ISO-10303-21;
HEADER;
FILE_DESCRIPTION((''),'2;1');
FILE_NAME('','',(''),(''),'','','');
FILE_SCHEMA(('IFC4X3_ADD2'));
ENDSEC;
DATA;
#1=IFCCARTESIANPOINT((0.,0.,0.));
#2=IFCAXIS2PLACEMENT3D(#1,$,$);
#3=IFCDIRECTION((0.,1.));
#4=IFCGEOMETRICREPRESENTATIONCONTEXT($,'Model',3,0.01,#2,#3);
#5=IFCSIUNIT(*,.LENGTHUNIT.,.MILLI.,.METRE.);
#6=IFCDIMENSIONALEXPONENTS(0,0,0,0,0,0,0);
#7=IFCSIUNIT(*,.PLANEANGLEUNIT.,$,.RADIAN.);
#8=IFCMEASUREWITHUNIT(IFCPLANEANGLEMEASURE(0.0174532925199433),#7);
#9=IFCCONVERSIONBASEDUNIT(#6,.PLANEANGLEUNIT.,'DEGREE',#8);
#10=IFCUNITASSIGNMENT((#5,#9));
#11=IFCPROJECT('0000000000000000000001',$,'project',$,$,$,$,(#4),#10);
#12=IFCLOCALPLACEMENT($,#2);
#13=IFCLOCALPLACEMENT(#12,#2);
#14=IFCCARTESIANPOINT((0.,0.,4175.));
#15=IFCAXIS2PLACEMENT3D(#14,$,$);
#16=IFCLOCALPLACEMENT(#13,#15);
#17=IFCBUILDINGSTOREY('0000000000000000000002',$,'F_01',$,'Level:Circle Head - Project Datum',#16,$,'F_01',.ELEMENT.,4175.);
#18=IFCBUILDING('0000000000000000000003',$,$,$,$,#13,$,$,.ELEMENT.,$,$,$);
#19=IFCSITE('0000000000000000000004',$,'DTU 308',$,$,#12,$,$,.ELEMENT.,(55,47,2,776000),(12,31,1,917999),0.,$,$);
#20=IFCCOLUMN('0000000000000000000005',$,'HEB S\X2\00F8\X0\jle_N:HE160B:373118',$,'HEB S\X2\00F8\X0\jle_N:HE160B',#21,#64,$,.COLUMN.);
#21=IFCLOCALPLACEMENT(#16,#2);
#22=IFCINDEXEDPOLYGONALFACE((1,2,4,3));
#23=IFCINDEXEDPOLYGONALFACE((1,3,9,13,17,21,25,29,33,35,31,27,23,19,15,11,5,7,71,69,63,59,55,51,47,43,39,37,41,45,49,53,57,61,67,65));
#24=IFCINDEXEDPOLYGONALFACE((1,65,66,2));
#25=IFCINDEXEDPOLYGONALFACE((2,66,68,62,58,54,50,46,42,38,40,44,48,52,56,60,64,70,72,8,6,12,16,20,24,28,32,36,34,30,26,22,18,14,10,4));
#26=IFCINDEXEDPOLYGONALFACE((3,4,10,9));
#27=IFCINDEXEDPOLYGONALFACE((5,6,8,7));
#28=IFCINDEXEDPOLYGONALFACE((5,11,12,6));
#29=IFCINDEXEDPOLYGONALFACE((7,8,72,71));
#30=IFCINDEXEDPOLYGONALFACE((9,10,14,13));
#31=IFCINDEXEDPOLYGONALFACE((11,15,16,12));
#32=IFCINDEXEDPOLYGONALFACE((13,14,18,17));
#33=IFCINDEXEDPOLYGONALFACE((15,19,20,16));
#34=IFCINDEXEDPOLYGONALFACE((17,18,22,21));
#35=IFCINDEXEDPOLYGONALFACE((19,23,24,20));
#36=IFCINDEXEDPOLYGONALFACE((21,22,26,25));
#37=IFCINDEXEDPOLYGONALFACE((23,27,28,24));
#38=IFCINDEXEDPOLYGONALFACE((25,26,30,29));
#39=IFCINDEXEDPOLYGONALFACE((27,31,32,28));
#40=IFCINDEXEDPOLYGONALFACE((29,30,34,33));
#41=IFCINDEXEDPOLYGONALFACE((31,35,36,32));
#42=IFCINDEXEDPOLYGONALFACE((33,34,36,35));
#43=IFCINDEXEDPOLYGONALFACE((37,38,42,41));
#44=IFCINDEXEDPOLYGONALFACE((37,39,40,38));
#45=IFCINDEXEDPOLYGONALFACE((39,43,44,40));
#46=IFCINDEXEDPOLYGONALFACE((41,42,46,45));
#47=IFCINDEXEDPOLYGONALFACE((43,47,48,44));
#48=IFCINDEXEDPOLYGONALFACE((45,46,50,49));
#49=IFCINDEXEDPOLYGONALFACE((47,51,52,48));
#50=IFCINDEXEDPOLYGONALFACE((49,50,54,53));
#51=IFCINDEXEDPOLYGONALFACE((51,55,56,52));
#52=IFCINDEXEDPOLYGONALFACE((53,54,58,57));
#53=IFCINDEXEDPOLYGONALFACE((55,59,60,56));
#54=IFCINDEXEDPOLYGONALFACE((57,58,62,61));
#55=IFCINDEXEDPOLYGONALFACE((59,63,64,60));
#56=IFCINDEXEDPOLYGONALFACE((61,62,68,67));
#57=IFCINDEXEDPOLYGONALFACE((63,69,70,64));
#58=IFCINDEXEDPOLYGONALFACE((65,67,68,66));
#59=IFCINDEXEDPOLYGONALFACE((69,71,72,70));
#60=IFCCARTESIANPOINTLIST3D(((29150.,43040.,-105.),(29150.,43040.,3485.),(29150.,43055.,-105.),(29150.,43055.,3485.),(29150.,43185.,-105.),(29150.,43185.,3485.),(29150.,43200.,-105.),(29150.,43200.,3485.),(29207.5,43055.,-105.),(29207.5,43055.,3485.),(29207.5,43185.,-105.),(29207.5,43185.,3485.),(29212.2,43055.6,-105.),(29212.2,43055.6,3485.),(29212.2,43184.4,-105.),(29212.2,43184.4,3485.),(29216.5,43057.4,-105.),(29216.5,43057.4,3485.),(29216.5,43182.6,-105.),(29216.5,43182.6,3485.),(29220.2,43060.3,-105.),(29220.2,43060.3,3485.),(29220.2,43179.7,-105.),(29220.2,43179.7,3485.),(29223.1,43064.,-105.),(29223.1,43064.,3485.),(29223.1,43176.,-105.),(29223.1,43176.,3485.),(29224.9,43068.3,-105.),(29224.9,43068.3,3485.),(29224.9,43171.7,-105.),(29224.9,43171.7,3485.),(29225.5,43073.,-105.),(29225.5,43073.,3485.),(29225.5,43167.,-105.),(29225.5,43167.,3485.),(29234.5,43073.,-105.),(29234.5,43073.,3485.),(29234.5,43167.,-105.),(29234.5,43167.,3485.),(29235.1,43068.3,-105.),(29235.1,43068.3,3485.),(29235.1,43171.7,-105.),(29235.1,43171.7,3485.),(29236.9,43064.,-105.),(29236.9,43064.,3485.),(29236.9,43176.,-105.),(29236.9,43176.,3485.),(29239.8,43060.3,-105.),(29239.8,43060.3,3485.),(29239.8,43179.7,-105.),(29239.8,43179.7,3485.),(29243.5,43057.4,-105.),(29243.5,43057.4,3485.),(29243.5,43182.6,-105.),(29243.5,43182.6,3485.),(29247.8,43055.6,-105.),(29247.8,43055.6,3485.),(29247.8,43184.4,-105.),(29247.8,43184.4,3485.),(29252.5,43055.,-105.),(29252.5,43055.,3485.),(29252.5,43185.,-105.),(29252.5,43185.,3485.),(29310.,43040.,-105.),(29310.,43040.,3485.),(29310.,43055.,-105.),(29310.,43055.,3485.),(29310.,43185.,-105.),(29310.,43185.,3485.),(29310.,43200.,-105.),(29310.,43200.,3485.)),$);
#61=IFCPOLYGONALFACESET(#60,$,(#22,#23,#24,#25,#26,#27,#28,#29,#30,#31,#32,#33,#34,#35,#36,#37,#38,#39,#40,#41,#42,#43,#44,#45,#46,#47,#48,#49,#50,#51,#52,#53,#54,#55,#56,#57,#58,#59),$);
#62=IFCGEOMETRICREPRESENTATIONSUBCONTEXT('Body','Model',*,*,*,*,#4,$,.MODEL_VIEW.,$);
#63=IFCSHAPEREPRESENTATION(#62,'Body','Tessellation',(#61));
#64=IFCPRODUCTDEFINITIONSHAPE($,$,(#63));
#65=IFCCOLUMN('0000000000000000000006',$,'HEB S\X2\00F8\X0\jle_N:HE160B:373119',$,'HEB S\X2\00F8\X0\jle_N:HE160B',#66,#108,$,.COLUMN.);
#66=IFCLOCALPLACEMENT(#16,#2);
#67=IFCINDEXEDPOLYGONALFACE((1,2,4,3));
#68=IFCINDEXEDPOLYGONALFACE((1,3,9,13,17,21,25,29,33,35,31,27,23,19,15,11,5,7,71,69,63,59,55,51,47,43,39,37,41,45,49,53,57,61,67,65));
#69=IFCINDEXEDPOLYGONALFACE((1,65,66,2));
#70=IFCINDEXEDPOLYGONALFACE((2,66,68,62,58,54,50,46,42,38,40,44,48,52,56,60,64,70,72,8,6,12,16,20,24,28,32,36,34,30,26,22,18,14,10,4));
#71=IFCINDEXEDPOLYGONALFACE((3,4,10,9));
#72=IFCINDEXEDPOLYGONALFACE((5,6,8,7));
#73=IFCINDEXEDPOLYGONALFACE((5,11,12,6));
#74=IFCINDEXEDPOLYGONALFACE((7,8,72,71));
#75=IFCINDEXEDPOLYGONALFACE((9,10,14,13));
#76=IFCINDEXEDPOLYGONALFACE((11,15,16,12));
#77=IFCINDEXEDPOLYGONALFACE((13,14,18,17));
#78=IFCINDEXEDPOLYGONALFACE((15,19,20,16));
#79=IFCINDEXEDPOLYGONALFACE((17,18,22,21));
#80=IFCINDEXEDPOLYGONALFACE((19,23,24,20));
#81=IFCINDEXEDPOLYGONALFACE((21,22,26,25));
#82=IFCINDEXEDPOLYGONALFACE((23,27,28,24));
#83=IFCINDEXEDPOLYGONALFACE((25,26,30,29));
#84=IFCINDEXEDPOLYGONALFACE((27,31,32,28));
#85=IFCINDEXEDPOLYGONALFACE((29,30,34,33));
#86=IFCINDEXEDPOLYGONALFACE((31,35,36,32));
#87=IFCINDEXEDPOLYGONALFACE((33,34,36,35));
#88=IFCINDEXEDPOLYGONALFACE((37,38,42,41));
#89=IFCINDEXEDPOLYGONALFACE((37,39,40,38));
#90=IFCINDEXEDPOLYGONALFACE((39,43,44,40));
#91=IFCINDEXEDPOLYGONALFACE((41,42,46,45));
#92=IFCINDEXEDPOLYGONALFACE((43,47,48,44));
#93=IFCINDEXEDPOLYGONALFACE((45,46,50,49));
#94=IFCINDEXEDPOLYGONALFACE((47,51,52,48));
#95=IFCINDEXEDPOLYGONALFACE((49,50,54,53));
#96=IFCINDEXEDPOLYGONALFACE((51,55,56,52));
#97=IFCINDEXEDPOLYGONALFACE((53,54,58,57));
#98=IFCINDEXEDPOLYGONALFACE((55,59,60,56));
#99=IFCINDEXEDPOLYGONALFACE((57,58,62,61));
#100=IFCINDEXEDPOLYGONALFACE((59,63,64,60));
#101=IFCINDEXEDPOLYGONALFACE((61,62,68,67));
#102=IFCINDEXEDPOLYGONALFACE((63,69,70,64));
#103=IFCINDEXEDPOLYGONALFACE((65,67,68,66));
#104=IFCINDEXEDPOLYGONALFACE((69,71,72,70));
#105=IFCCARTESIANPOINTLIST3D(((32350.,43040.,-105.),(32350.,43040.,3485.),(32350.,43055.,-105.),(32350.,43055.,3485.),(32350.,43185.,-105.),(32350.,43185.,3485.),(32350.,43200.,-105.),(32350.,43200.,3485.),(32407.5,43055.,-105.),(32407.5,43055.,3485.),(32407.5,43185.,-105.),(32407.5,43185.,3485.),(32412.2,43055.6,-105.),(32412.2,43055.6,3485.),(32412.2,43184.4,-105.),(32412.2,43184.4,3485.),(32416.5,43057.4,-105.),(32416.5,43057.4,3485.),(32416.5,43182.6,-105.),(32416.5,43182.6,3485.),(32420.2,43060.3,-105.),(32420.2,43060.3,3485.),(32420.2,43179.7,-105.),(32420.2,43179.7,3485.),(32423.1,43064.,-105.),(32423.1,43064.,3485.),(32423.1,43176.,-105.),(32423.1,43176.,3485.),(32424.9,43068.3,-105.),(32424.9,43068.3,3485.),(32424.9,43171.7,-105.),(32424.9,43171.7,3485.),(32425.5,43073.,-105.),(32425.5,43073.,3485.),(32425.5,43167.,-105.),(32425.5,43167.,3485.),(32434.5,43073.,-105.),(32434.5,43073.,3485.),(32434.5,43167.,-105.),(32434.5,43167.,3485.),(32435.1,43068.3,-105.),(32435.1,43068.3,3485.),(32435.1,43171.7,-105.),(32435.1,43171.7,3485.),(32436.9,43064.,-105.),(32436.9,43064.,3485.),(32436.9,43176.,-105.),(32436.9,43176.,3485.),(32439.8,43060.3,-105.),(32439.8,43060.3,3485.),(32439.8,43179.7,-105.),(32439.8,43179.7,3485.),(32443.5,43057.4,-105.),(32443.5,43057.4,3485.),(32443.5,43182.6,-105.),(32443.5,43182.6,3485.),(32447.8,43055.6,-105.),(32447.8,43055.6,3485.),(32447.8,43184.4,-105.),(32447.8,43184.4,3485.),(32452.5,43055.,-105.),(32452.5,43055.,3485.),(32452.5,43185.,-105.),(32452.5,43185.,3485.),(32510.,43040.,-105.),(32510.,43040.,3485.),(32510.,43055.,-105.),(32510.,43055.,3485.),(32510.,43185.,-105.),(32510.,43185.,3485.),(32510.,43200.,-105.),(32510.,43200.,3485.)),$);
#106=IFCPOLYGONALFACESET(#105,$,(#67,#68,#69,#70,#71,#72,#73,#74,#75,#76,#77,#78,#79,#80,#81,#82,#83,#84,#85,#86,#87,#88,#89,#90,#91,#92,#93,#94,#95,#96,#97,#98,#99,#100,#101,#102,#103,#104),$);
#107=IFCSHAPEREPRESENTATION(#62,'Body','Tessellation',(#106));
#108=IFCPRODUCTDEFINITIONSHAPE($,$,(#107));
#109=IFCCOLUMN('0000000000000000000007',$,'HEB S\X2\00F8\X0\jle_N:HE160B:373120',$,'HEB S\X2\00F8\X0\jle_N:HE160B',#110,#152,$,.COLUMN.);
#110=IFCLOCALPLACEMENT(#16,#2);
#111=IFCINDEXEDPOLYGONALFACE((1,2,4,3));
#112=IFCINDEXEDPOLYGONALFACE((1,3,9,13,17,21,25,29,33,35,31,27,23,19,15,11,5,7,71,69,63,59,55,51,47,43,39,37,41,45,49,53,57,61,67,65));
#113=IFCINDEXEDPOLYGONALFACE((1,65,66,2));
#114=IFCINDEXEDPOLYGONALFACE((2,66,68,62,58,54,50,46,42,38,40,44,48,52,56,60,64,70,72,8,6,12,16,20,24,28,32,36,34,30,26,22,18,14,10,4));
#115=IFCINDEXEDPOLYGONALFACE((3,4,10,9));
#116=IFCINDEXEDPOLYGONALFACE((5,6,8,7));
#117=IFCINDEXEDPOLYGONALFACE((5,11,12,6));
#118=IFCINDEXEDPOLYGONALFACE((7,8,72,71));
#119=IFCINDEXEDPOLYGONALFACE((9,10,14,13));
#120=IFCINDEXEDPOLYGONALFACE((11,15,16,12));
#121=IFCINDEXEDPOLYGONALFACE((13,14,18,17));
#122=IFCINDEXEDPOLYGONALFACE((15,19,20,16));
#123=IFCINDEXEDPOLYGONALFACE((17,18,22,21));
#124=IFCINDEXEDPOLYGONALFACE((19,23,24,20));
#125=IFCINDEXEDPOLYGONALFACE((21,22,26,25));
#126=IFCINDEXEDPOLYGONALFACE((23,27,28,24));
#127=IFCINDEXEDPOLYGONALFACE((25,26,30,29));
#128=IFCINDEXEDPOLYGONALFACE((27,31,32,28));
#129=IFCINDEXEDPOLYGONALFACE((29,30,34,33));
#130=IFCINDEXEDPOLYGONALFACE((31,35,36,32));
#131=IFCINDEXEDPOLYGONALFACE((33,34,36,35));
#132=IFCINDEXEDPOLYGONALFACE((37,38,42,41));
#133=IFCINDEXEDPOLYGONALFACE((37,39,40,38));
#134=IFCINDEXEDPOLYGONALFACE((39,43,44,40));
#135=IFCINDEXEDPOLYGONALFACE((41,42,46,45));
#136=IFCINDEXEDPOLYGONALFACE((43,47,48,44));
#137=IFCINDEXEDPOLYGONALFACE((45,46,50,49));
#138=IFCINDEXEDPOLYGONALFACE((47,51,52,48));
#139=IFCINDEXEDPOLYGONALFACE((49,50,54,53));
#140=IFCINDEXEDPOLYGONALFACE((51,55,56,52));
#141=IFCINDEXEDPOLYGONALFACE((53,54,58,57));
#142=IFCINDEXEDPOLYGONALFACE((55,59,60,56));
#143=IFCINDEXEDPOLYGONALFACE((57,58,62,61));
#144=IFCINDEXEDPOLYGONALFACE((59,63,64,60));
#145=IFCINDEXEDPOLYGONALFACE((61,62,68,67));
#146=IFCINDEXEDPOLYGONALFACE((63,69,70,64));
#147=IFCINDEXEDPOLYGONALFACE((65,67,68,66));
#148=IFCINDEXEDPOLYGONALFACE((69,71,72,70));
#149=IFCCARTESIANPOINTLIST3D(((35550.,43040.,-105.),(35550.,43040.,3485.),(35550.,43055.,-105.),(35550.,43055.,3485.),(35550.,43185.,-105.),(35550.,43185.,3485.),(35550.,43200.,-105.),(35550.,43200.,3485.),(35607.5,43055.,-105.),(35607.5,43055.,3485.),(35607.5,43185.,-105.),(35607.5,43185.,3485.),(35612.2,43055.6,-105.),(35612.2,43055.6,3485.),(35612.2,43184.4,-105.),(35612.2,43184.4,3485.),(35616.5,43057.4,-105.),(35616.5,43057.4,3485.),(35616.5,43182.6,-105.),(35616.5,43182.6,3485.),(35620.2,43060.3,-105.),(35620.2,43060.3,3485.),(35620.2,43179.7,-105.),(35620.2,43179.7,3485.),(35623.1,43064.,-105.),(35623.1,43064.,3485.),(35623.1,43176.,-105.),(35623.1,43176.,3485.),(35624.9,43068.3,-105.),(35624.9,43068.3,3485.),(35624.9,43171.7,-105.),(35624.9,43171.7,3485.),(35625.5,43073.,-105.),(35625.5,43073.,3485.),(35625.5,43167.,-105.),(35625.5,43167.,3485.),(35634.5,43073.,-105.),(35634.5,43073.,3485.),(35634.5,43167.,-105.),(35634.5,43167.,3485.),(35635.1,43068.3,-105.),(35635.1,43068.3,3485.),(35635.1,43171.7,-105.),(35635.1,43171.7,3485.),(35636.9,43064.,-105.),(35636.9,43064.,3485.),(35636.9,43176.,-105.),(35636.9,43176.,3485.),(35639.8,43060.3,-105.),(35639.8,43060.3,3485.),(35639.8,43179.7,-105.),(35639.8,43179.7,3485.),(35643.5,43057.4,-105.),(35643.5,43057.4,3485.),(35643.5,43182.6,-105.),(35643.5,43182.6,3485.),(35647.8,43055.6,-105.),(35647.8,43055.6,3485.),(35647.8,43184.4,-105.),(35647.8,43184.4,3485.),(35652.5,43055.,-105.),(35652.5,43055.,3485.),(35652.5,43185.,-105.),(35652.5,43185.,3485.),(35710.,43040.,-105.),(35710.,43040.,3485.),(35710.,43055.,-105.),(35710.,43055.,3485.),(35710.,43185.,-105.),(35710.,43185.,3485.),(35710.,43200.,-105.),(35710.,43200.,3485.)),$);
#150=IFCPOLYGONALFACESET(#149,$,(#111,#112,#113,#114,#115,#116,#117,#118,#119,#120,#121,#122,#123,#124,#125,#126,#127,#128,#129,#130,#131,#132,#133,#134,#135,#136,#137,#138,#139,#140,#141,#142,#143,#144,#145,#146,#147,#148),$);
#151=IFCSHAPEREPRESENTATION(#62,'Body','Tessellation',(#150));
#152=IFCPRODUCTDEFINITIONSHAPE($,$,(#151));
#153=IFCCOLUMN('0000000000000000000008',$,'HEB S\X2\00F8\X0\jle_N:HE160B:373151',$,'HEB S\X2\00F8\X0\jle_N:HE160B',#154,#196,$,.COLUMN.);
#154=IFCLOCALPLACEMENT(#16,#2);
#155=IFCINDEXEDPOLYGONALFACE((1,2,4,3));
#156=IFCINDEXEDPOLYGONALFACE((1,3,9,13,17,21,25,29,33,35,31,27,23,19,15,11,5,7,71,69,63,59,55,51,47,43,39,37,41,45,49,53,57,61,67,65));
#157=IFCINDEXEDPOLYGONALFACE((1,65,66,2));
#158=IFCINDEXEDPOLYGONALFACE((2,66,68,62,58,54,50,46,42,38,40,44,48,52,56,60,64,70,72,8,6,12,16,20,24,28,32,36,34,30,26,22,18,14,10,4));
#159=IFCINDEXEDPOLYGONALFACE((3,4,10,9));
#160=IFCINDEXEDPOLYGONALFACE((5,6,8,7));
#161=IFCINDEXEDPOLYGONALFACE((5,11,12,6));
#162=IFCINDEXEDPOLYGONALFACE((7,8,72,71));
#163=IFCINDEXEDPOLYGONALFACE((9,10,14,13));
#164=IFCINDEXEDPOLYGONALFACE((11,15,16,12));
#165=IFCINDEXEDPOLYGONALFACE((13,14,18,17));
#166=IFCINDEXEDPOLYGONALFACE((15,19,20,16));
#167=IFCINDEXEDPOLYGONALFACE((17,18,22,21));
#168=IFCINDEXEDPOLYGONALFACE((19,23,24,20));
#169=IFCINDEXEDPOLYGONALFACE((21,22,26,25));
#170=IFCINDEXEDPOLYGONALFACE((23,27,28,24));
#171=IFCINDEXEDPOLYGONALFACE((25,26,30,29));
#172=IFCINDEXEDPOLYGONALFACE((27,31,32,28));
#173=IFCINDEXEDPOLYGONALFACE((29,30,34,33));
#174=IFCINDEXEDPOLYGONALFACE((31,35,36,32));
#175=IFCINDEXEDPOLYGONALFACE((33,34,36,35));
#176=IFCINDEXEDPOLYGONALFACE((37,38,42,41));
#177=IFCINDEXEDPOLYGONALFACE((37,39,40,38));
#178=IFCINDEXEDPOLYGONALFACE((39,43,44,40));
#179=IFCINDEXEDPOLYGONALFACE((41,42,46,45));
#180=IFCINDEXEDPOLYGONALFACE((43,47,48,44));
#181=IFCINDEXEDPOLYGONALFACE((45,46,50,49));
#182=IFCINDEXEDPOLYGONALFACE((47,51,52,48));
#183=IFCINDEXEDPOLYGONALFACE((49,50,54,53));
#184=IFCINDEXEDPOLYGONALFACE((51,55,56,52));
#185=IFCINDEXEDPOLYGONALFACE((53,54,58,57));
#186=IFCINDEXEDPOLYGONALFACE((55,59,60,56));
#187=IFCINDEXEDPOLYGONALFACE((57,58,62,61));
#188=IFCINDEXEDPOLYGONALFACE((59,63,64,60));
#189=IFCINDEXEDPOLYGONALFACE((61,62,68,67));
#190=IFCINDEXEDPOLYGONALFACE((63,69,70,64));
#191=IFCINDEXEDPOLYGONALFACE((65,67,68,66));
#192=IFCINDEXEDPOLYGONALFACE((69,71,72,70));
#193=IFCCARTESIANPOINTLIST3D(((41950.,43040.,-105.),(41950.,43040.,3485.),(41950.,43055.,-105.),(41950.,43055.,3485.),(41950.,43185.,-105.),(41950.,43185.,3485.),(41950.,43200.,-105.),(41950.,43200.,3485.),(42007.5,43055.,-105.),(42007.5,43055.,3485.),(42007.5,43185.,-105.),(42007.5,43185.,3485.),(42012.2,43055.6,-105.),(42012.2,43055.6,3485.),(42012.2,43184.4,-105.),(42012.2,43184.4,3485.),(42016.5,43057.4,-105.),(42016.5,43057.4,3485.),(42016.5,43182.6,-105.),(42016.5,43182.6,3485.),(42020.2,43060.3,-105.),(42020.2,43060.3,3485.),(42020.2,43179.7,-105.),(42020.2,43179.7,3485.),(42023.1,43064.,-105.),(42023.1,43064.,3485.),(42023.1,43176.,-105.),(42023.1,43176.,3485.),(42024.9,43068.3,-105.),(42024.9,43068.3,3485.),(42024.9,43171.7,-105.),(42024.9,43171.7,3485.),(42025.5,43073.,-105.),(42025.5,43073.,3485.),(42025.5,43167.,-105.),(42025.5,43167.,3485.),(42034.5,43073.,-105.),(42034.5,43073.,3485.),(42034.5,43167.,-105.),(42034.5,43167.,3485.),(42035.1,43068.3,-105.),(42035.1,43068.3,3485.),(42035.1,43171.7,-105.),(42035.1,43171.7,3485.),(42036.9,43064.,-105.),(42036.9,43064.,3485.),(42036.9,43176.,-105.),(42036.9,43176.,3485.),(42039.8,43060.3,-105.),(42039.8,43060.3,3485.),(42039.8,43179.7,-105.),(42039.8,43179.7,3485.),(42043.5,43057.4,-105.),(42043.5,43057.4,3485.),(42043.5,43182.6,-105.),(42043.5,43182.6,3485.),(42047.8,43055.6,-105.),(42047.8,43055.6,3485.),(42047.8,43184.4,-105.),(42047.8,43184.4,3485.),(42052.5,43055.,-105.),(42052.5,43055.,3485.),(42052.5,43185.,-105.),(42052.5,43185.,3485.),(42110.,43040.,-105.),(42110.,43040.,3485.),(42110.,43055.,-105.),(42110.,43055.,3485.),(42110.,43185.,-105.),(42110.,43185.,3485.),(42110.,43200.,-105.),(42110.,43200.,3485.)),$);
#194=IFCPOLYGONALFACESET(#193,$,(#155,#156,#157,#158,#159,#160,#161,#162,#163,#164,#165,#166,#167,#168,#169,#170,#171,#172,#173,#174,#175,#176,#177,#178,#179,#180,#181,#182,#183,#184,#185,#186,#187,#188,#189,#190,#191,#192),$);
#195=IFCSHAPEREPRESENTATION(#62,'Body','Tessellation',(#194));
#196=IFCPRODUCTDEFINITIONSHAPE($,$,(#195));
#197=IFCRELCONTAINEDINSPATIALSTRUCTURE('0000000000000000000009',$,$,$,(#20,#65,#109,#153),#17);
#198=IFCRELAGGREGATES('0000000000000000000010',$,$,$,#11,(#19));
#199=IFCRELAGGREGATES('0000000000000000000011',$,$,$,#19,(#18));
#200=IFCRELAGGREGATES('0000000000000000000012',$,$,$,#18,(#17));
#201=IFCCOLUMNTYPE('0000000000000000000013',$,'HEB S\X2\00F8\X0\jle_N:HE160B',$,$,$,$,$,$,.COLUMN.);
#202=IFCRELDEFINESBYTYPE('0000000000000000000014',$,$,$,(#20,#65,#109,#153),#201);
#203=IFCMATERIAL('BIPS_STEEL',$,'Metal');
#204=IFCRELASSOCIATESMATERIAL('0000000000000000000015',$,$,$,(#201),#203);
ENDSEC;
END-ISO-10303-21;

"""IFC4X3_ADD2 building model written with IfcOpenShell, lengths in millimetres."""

from ifc_helpers import new_model, entity, si_unit, converted_unit, direction, frame, frame_2d, origin, place, context, subcontext, project, spatial, i_section, extrude, source, transform, mapped, material, material_profile, profile_set, type_object, element, save


model = new_model("IFC4X3_ADD2")

# Units and contexts
model_context = context("Model", 3, precision=0.01, world=origin(), true_north=direction((0.0, 1.0)))
body_context = subcontext(model_context, "Body", "Model", "MODEL_VIEW")
ifc_project = project(units=[si_unit("LENGTHUNIT", "METRE", prefix="MILLI"), converted_unit("PLANEANGLEUNIT", "DEGREE", entity("IfcPlaneAngleMeasure", 0.0174532925199433), si_unit("PLANEANGLEUNIT", "RADIAN"), dimensions=[0, 0, 0, 0, 0, 0, 0])], contexts=[model_context])

# Site, building, storey
site_placement = place(None, origin())
site = spatial("IfcSite", under=ifc_project, at=site_placement, Name="DTU 308", CompositionType="ELEMENT", RefLatitude=(55, 47, 2, 776000), RefLongitude=(12, 31, 1, 917999), RefElevation=0.0)
building_placement = place(site_placement, origin())
building = spatial("IfcBuilding", under=site, at=building_placement, CompositionType="ELEMENT")
storey_placement = place(building_placement, frame((0.0, 0.0, 4175.0)))
storey = spatial("IfcBuildingStorey", under=building, at=storey_placement, Name="F_01", ObjectType="Level:Circle Head - Project Datum", LongName="F_01", CompositionType="ELEMENT", Elevation=4175.0)

# Columns
ifc_material_1 = material(Name="BIPS_STEEL", Category="Metal")
ifc_material_profile_1 = material_profile(ifc_material_1, i_section(OverallWidth=160.0, OverallDepth=160.0, WebThickness=9.0, FlangeThickness=15.0, FilletRadius=18.0, at=frame_2d((0.0, 0.0), x_axis=(1.0, 0.0))), Name="HE160B")
ifc_profile_set_1 = profile_set([ifc_material_profile_1], Name="HE160B")
column_type_1 = type_object("IfcColumnType", Name="HEB Søjle_N:HE160B", PredefinedType="COLUMN", material=ifc_profile_set_1)
shared_shape_1 = source(origin(), body_context, "Body", "SweptSolid", [
    extrude(i_section(OverallWidth=160.0, OverallDepth=160.0, WebThickness=9.0, FlangeThickness=15.0, FilletRadius=18.0, at=frame_2d((0.0, 0.0), x_axis=(1.0, 0.0))), frame((0.0, 0.0, 4070.0), z_axis=(0.0, 0.0, 1.0), x_axis=(-1.0, 0.0, 0.0)), (0.0, 0.0, 1.0), 3590.0),
])
for number, where, name in (
    (1, (29230.0, 43120.0, -4175.0), "HEB Søjle_N:HE160B:373118"),
    (2, (32430.0, 43120.0, -4175.0), "HEB Søjle_N:HE160B:373119"),
    (3, (35630.0, 43120.0, -4175.0), "HEB Søjle_N:HE160B:373120"),
    (4, (42030.0, 43120.0, -4175.0), "HEB Søjle_N:HE160B:373151"),
):
    element("IfcColumn", number, at=place(storey_placement, frame(where)), inside=storey, type_object=column_type_1, Name=name, ObjectType="HEB Søjle_N:HE160B", PredefinedType="COLUMN", context=body_context, shape_type="MappedRepresentation", body=[
        mapped(shared_shape_1, transform((0.0, 0.0, 0.0), scale=1.0)),
    ])

save(model, "model.ifc")
